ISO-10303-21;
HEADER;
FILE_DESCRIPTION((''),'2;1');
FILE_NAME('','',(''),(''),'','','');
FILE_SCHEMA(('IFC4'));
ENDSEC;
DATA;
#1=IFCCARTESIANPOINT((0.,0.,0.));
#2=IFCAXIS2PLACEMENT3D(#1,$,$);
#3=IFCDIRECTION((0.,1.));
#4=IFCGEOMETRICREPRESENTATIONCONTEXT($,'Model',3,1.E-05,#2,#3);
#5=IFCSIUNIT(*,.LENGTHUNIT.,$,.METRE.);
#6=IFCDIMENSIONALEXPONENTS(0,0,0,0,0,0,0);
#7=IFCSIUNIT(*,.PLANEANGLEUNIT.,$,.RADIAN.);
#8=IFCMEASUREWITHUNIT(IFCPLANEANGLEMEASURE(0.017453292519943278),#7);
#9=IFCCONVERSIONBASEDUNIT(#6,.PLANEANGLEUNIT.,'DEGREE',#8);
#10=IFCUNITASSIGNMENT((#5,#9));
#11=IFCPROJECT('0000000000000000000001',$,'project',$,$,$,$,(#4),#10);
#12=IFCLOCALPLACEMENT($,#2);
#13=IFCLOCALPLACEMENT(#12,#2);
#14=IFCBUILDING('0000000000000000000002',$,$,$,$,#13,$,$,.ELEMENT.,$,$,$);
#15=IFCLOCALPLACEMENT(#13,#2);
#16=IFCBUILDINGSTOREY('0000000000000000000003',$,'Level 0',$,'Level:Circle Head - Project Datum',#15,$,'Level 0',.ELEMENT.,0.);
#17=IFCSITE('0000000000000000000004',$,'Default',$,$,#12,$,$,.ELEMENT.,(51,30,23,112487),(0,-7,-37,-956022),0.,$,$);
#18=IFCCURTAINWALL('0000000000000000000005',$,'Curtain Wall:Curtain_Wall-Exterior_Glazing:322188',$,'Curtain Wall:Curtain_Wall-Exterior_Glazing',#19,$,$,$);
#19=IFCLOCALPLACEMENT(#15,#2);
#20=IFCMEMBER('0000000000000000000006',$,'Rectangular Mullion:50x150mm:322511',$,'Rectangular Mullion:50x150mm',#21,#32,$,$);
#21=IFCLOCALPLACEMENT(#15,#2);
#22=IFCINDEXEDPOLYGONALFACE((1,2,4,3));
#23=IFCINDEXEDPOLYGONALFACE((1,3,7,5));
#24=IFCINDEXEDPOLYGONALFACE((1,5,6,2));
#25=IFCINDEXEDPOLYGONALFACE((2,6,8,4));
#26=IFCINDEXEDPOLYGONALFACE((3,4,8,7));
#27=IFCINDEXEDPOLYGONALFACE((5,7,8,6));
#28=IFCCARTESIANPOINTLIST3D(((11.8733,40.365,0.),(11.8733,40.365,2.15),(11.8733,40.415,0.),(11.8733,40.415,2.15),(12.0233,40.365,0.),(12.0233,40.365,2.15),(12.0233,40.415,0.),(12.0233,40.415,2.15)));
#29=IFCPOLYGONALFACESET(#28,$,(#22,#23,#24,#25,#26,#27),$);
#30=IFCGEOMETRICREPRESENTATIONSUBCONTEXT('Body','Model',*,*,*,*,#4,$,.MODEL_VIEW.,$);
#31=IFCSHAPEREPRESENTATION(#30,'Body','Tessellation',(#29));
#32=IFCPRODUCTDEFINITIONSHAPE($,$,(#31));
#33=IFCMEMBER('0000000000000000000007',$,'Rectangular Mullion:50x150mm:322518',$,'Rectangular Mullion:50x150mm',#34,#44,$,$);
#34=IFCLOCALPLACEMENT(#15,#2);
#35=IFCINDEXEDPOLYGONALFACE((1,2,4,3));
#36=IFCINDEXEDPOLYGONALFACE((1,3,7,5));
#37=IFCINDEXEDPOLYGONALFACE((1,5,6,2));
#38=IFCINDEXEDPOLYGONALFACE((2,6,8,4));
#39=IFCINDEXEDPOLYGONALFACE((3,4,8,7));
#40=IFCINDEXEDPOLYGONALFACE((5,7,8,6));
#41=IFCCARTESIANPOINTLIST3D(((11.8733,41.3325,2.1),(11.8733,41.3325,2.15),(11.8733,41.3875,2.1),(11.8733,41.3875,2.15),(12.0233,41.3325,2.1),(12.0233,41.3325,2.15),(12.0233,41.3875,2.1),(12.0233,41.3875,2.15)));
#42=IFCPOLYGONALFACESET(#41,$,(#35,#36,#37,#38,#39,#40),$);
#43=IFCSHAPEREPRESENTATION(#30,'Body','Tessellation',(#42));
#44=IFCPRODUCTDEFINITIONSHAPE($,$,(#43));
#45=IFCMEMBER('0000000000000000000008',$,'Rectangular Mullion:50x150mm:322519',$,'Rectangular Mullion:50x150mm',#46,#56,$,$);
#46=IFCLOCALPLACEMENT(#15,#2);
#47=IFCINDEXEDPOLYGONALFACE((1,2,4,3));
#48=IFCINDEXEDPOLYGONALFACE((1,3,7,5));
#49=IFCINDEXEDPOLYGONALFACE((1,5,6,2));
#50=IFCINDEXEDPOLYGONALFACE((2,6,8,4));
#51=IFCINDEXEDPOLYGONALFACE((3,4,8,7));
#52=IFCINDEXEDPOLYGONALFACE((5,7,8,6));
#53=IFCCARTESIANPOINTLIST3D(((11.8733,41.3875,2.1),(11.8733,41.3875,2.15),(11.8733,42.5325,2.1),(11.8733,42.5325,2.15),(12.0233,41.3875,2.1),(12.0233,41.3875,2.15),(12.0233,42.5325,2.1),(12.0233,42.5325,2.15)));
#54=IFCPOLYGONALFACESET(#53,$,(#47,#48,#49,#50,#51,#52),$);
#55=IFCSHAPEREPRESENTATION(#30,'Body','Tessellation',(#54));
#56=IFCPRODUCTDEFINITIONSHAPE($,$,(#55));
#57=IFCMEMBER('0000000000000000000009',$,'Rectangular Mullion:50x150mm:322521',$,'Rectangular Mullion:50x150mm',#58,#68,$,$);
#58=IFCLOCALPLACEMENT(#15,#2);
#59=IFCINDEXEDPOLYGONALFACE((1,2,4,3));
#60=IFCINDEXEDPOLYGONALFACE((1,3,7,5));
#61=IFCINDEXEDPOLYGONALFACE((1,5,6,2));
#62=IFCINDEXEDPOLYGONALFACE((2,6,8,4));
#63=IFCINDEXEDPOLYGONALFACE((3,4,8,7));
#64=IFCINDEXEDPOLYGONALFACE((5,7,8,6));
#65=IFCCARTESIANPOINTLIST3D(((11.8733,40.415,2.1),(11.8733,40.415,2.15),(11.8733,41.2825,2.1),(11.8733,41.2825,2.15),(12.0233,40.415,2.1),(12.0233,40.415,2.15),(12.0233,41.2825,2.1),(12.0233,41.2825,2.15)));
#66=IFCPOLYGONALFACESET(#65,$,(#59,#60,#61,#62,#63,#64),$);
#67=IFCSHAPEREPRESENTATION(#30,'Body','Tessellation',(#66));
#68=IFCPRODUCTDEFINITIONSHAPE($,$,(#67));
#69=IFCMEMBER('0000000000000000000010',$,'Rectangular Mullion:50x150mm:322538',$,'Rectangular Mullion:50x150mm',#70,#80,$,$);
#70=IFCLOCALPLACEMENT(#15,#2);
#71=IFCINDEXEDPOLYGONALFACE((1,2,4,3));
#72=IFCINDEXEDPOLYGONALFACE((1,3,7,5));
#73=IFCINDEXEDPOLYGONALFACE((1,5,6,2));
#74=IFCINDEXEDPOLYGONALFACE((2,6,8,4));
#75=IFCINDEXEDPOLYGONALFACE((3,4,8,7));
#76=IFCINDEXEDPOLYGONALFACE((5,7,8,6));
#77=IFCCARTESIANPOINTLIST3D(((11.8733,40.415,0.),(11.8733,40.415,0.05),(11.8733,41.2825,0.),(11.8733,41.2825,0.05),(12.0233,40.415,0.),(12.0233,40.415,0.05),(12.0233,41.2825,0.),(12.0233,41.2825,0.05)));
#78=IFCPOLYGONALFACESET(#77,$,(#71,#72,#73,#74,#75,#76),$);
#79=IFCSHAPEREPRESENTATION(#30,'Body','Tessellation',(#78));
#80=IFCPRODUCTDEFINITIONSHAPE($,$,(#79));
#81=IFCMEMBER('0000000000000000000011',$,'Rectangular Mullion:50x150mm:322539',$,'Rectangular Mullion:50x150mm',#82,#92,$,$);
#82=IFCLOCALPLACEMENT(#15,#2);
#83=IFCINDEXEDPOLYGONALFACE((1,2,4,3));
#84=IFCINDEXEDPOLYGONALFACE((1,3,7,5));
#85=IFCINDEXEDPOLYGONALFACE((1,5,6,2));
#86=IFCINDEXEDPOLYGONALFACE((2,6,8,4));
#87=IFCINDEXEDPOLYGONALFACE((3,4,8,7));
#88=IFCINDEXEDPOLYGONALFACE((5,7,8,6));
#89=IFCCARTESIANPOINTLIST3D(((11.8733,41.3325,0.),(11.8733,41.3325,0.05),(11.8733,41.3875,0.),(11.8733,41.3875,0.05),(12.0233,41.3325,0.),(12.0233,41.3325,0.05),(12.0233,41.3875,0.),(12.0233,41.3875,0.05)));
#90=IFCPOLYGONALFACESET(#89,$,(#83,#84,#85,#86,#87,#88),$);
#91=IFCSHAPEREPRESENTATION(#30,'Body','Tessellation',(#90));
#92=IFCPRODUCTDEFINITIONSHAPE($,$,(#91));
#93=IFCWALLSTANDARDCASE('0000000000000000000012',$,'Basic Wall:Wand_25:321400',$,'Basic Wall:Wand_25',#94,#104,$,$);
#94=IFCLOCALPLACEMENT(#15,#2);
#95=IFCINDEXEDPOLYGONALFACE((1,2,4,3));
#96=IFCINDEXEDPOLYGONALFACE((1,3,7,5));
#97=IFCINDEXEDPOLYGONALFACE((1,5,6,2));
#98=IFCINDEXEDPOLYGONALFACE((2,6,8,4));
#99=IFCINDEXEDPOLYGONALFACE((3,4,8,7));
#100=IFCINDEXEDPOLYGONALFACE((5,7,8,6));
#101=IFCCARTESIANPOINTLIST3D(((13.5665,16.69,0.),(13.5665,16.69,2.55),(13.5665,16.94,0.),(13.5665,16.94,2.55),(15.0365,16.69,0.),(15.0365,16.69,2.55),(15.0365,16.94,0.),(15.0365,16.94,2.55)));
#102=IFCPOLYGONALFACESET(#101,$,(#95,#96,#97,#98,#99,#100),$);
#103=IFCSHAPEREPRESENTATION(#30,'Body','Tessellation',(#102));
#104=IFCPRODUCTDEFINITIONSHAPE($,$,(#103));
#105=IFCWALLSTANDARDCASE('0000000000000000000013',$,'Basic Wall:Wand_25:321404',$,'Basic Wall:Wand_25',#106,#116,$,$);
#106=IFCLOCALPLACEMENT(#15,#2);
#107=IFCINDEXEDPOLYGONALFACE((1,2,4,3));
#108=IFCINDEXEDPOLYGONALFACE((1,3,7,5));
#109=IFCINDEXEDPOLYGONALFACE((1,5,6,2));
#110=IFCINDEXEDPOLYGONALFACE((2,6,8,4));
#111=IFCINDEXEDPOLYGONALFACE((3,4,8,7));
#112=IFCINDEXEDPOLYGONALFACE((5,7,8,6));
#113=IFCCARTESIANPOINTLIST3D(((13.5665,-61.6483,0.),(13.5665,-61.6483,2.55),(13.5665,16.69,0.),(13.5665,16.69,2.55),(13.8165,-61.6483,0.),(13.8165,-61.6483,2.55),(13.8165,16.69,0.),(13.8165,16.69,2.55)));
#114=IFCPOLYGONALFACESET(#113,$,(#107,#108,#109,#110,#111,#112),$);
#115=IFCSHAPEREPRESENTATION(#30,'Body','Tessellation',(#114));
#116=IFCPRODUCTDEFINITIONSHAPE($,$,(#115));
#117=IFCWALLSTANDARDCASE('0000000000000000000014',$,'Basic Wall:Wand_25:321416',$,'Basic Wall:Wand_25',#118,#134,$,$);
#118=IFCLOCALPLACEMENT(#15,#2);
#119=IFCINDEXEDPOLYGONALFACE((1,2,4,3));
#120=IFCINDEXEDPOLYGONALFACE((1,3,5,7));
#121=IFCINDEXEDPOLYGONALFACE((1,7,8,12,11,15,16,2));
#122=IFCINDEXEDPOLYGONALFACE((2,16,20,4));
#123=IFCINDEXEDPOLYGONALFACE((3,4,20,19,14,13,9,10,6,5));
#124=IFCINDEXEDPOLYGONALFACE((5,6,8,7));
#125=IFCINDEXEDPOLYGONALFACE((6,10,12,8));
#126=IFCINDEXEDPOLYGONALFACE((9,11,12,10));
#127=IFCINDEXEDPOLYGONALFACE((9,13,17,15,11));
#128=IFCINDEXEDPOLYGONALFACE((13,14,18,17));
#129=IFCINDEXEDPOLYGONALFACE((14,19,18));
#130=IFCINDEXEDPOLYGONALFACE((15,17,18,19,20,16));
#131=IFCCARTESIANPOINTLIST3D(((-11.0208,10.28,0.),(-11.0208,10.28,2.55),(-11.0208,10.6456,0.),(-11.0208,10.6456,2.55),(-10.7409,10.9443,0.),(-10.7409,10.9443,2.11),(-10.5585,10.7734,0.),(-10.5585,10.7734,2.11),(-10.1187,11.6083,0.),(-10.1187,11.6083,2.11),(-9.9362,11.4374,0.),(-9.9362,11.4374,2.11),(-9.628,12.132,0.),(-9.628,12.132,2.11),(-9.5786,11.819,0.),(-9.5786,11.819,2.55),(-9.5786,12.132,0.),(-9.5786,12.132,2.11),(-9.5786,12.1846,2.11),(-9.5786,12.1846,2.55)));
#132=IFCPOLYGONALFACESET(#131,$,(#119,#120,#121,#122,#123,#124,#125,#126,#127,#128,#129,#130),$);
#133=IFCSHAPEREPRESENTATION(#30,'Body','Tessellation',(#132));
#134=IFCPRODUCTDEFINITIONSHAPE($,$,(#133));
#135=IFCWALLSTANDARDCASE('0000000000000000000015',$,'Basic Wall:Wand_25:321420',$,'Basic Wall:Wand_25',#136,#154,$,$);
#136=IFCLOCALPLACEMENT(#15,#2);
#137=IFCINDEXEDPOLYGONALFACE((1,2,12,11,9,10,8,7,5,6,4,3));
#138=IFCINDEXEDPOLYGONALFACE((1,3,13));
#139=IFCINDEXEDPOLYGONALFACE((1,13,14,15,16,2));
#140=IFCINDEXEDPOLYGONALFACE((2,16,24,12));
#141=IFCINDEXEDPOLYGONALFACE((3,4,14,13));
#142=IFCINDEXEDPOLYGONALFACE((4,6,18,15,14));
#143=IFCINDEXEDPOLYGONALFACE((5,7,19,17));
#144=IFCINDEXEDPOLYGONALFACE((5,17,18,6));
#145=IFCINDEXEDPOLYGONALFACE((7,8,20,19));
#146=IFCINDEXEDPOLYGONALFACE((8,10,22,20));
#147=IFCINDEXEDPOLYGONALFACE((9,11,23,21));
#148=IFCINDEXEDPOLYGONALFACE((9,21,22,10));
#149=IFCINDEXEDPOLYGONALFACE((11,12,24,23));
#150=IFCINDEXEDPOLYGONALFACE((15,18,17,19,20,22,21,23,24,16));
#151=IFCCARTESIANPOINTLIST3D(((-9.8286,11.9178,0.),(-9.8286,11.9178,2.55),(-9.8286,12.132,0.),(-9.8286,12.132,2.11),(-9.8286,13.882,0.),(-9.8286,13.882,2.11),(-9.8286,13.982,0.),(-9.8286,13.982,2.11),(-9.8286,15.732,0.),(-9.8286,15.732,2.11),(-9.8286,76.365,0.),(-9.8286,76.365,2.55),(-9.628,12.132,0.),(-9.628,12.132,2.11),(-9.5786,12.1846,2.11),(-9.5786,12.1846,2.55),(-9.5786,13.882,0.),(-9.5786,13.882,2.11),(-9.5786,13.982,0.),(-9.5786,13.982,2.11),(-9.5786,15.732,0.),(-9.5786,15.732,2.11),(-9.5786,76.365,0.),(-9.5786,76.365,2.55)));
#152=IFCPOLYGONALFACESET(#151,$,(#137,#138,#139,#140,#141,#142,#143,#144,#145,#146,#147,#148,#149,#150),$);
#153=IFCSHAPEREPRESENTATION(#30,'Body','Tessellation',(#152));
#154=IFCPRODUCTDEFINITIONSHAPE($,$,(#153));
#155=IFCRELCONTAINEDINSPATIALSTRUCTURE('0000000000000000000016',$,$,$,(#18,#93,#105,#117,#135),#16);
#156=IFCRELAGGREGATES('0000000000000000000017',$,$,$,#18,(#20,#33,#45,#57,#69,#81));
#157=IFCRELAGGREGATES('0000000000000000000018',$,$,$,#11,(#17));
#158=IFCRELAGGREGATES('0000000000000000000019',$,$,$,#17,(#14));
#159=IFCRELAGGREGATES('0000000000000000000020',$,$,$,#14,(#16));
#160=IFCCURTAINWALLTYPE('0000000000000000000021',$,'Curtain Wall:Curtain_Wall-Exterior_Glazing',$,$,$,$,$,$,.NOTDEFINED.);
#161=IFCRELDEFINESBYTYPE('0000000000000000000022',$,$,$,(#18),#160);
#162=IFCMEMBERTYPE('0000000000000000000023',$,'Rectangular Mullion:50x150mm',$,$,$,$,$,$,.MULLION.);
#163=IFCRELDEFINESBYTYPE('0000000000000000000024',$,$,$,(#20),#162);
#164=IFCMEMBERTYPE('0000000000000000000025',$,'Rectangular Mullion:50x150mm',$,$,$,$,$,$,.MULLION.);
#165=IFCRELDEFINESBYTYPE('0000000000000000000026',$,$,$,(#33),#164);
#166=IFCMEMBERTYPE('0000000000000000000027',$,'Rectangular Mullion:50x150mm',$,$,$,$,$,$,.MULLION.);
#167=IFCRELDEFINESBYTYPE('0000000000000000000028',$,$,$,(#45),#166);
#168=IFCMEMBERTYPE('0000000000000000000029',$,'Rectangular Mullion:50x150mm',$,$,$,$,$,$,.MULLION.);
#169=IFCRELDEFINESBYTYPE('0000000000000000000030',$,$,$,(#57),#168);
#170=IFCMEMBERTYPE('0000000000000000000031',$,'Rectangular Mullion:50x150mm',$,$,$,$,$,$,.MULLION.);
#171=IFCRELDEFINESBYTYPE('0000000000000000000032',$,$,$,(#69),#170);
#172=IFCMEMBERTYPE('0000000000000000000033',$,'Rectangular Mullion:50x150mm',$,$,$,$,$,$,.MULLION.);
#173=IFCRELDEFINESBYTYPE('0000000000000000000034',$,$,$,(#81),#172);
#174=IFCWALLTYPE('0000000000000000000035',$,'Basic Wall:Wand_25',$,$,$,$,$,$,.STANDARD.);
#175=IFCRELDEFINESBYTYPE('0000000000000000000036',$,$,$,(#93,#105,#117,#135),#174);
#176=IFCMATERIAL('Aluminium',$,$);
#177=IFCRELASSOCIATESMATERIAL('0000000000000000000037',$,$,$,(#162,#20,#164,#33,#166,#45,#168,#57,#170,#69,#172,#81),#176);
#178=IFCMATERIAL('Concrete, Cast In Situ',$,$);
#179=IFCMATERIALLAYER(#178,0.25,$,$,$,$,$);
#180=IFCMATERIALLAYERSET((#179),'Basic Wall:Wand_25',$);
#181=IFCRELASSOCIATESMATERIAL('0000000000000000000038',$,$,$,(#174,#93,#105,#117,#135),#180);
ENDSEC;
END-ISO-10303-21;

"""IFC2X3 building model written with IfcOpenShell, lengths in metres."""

from ifc_helpers import new_model, entity, si_unit, converted_unit, direction, frame, frame_2d, origin, origin_2d_with_axis, place, context, subcontext, project, spatial, polyline, rectangle, outline, extrude, source, transform, mapped, material, layer, layer_set, layer_usage, type_object, type_shapes, element, aggregate, save


model = new_model("IFC2X3")

# Units and contexts
model_context = context("Model", 3, precision=1e-05, world=origin(), true_north=direction((0.0, 1.0)))
body_context = subcontext(model_context, "Body", "Model", "MODEL_VIEW")
ifc_project = project(units=[si_unit("LENGTHUNIT", "METRE"), converted_unit("PLANEANGLEUNIT", "DEGREE", entity("IfcPlaneAngleMeasure", 0.017453292519943278), si_unit("PLANEANGLEUNIT", "RADIAN"), dimensions=[0, 0, 0, 0, 0, 0, 0])], contexts=[model_context])

# Site, building, storey
site_placement = place(None, origin())
site = spatial("IfcSite", under=ifc_project, at=site_placement, Name="Default", CompositionType="ELEMENT", RefLatitude=(51, 30, 23, 112487), RefLongitude=(0, -7, -37, -956022), RefElevation=0.0)
building_placement = place(site_placement, origin())
building = spatial("IfcBuilding", under=site, at=building_placement, CompositionType="ELEMENT")
storey_placement = place(building_placement, origin())
storey = spatial("IfcBuildingStorey", under=building, at=storey_placement, Name="Level 0", ObjectType="Level:Circle Head - Project Datum", LongName="Level 0", CompositionType="ELEMENT", Elevation=0.0)

# Curtain wall, members
curtain_wall_type = type_object("IfcCurtainWallType", Name="Curtain Wall:Curtain_Wall-Exterior_Glazing", PredefinedType="NOTDEFINED")
curtain_wall_placement = place(storey_placement, origin())
curtain_wall = element("IfcCurtainWall", 1, at=curtain_wall_placement, inside=storey, type_object=curtain_wall_type, Name="Curtain Wall:Curtain_Wall-Exterior_Glazing:322188", ObjectType="Curtain Wall:Curtain_Wall-Exterior_Glazing")
ifc_material_1 = material(Name="Aluminium")
member_type_1 = type_object("IfcMemberType", Name="Rectangular Mullion:50x150mm", PredefinedType="MULLION", material=ifc_material_1)
shared_shape_1 = source(origin(), body_context, "Body", "SweptSolid", [
    extrude(rectangle(XDim=0.05, YDim=0.15, at=origin_2d_with_axis()), frame((-0.025, 0.0, -2.15), z_axis=(0.0, 0.0, 1.0), x_axis=(-1.0, 0.0, 0.0)), (0.0, 0.0, 1.0), 2.15),
])
type_shapes(member_type_1, [shared_shape_1])
member_1_placement = place(curtain_wall_placement, frame((11.9483, 40.365, 0.0), z_axis=(0.0, 0.0, -1.0), x_axis=(0.0, -1.0, 0.0)))
member_1 = element("IfcMember", 2, at=member_1_placement, type_object=member_type_1, material=ifc_material_1, Name="Rectangular Mullion:50x150mm:322511", ObjectType="Rectangular Mullion:50x150mm", context=body_context, shape_type="MappedRepresentation", body=[
    mapped(shared_shape_1, transform((0.0, 0.0, 0.0), scale=1.0)),
])
member_type_2 = type_object("IfcMemberType", Name="Rectangular Mullion:50x150mm", PredefinedType="MULLION", material=ifc_material_1)
shared_shape_2 = source(origin(), body_context, "Body", "SweptSolid", [
    extrude(rectangle(XDim=0.05, YDim=0.15, at=origin_2d_with_axis()), frame((-0.025, 0.0, -0.055), z_axis=(0.0, 0.0, 1.0), x_axis=(-1.0, 0.0, 0.0)), (0.0, 0.0, 1.0), 0.055),
])
type_shapes(member_type_2, [shared_shape_2])
member_2_placement = place(curtain_wall_placement, frame((11.9483, 41.3325, 2.15), z_axis=(0.0, -1.0, 0.0), x_axis=(0.0, 0.0, 1.0)))
member_2 = element("IfcMember", 3, at=member_2_placement, type_object=member_type_2, material=ifc_material_1, Name="Rectangular Mullion:50x150mm:322518", ObjectType="Rectangular Mullion:50x150mm", context=body_context, shape_type="MappedRepresentation", body=[
    mapped(shared_shape_2, transform((0.0, 0.0, 0.0), scale=1.0)),
])
member_type_3 = type_object("IfcMemberType", Name="Rectangular Mullion:50x150mm", PredefinedType="MULLION", material=ifc_material_1)
shared_shape_3 = source(origin(), body_context, "Body", "SweptSolid", [
    extrude(rectangle(XDim=0.05, YDim=0.15, at=origin_2d_with_axis()), frame((-0.025, 0.0, -1.145), z_axis=(0.0, 0.0, 1.0), x_axis=(-1.0, 0.0, 0.0)), (0.0, 0.0, 1.0), 1.145),
])
type_shapes(member_type_3, [shared_shape_3])
member_3_placement = place(curtain_wall_placement, frame((11.9483, 41.3875, 2.15), z_axis=(0.0, -1.0, 0.0), x_axis=(0.0, 0.0, 1.0)))
member_3 = element("IfcMember", 4, at=member_3_placement, type_object=member_type_3, material=ifc_material_1, Name="Rectangular Mullion:50x150mm:322519", ObjectType="Rectangular Mullion:50x150mm", context=body_context, shape_type="MappedRepresentation", body=[
    mapped(shared_shape_3, transform((0.0, 0.0, 0.0), scale=1.0)),
])
member_type_4 = type_object("IfcMemberType", Name="Rectangular Mullion:50x150mm", PredefinedType="MULLION", material=ifc_material_1)
shared_shape_4 = source(origin(), body_context, "Body", "SweptSolid", [
    extrude(rectangle(XDim=0.05, YDim=0.15, at=origin_2d_with_axis()), frame((-0.025, 0.0, -0.8675), z_axis=(0.0, 0.0, 1.0), x_axis=(-1.0, 0.0, 0.0)), (0.0, 0.0, 1.0), 0.8675),
])
type_shapes(member_type_4, [shared_shape_4])
member_4_placement = place(curtain_wall_placement, frame((11.9483, 40.415, 2.15), z_axis=(0.0, -1.0, 0.0), x_axis=(0.0, 0.0, 1.0)))
member_4 = element("IfcMember", 5, at=member_4_placement, type_object=member_type_4, material=ifc_material_1, Name="Rectangular Mullion:50x150mm:322521", ObjectType="Rectangular Mullion:50x150mm", context=body_context, shape_type="MappedRepresentation", body=[
    mapped(shared_shape_4, transform((0.0, 0.0, 0.0), scale=1.0)),
])
member_type_5 = type_object("IfcMemberType", Name="Rectangular Mullion:50x150mm", PredefinedType="MULLION", material=ifc_material_1)
shared_shape_5 = source(origin(), body_context, "Body", "SweptSolid", [
    extrude(rectangle(XDim=0.05, YDim=0.15, at=origin_2d_with_axis()), frame((-0.025, 0.0, -0.8675), z_axis=(0.0, 0.0, 1.0), x_axis=(-1.0, 0.0, 0.0)), (0.0, 0.0, 1.0), 0.8675),
])
type_shapes(member_type_5, [shared_shape_5])
member_5_placement = place(curtain_wall_placement, frame((11.9483, 41.2825, 0.0), z_axis=(0.0, 1.0, 0.0), x_axis=(0.0, 0.0, -1.0)))
member_5 = element("IfcMember", 6, at=member_5_placement, type_object=member_type_5, material=ifc_material_1, Name="Rectangular Mullion:50x150mm:322538", ObjectType="Rectangular Mullion:50x150mm", context=body_context, shape_type="MappedRepresentation", body=[
    mapped(shared_shape_5, transform((0.0, 0.0, 0.0), scale=1.0)),
])
member_type_6 = type_object("IfcMemberType", Name="Rectangular Mullion:50x150mm", PredefinedType="MULLION", material=ifc_material_1)
shared_shape_6 = source(origin(), body_context, "Body", "SweptSolid", [
    extrude(rectangle(XDim=0.05, YDim=0.15, at=origin_2d_with_axis()), frame((-0.025, 0.0, -0.055), z_axis=(0.0, 0.0, 1.0), x_axis=(-1.0, 0.0, 0.0)), (0.0, 0.0, 1.0), 0.055),
])
type_shapes(member_type_6, [shared_shape_6])
member_6_placement = place(curtain_wall_placement, frame((11.9483, 41.3875, 0.0), z_axis=(0.0, 1.0, 0.0), x_axis=(0.0, 0.0, -1.0)))
member_6 = element("IfcMember", 7, at=member_6_placement, type_object=member_type_6, material=ifc_material_1, Name="Rectangular Mullion:50x150mm:322539", ObjectType="Rectangular Mullion:50x150mm", context=body_context, shape_type="MappedRepresentation", body=[
    mapped(shared_shape_6, transform((0.0, 0.0, 0.0), scale=1.0)),
])
aggregate(curtain_wall, [member_1, member_2, member_3, member_4, member_5, member_6])

# Walls
ifc_material_2 = material(Name="Concrete, Cast In Situ")
ifc_layer_1 = layer(ifc_material_2, 0.25)
ifc_layer_set_1 = layer_set([ifc_layer_1], Name="Basic Wall:Wand_25")
ifc_layer_usage_1 = layer_usage(ifc_layer_set_1, "AXIS2", "NEGATIVE", 0.125)
wall_type_1 = type_object("IfcWallType", Name="Basic Wall:Wand_25", PredefinedType="STANDARD", material=ifc_layer_set_1)
wall_1_placement = place(storey_placement, frame((15.0365, 16.815, 0.0), z_axis=(0.0, 0.0, 1.0), x_axis=(-1.0, 0.0, 0.0)))
element("IfcWallStandardCase", 8, at=wall_1_placement, inside=storey, type_object=wall_type_1, material=ifc_layer_usage_1, Name="Basic Wall:Wand_25:321400", ObjectType="Basic Wall:Wand_25", context=body_context, shape_type="SweptSolid", body=[
    extrude(rectangle(XDim=1.47, YDim=0.25, at=frame_2d((0.735, 0.0), x_axis=(-1.0, 0.0))), origin(), (0.0, 0.0, 1.0), 2.55),
])
wall_2_placement = place(storey_placement, frame((13.6915, 16.69, 0.0), z_axis=(0.0, 0.0, 1.0), x_axis=(0.0, -1.0, 0.0)))
element("IfcWallStandardCase", 9, at=wall_2_placement, inside=storey, type_object=wall_type_1, material=ifc_layer_usage_1, Name="Basic Wall:Wand_25:321404", ObjectType="Basic Wall:Wand_25", context=body_context, shape_type="SweptSolid", body=[
    extrude(rectangle(XDim=78.3384, YDim=0.25, at=frame_2d((39.1692, 0.0), x_axis=(-1.0, 0.0))), origin(), (0.0, 0.0, 1.0), 2.55),
])

# Walls, openings
wall_3_placement = place(storey_placement, frame((-11.1121, 10.3655, 0.0), z_axis=(0.0, 0.0, 1.0), x_axis=(0.683795, 0.729674, 0.0)))
wall_3 = element("IfcWallStandardCase", 10, at=wall_3_placement, inside=storey, type_object=wall_type_1, material=ifc_layer_usage_1, Name="Basic Wall:Wand_25:321416", ObjectType="Basic Wall:Wand_25", context=body_context, shape_type="SweptSolid", body=[
    extrude(outline(polyline([(0.0, -0.125), (2.1092, -0.125), (2.3759, 0.125), (2.0103, 0.125), (0.2668, 0.125), (0.0, -0.125)])), origin(), (0.0, 0.0, 1.0), 2.55),
])
opening_1_placement = place(wall_3_placement, origin())
element("IfcOpeningElement", 11, at=opening_1_placement, cuts=wall_3, ObjectType="Opening", context=body_context, shape_type="SweptSolid", body=[
    extrude(rectangle(XDim=2.11, YDim=1.75, at=frame_2d((0.0, 0.0), x_axis=(0.0, 1.0))), frame((2.976, 0.6873, 1.055), z_axis=(-0.683795, 0.729674, 0.0), x_axis=(0.729674, 0.683795, 0.0)), (0.0, 0.0, 1.0), 0.25),
])
opening_2_placement = place(wall_3_placement, frame((1.5862, 0.125, 0.0)))
element("IfcOpeningElement", 12, at=opening_2_placement, cuts=wall_3, ObjectType="Opening", context=body_context, shape_type="SweptSolid", body=[
    extrude(rectangle(XDim=2.11, YDim=0.91, at=frame_2d((1.055, 0.455), x_axis=(1.0, 0.0))), frame((0.0, 0.0, 0.0), z_axis=(0.0, -1.0, 0.0), x_axis=(0.0, 0.0, 1.0)), (0.0, 0.0, 1.0), 0.25),
])
wall_4_placement = place(storey_placement, frame((-9.7036, 11.9178, 0.0), z_axis=(0.0, 0.0, 1.0), x_axis=(0.0, 1.0, 0.0)))
wall_4 = element("IfcWallStandardCase", 13, at=wall_4_placement, inside=storey, type_object=wall_type_1, material=ifc_layer_usage_1, Name="Basic Wall:Wand_25:321420", ObjectType="Basic Wall:Wand_25", context=body_context, shape_type="SweptSolid", body=[
    extrude(outline(polyline([(0.2668, -0.125), (64.4472, -0.125), (64.4472, 0.125), (0.0, 0.125), (0.2668, -0.125)])), origin(), (0.0, 0.0, 1.0), 2.55),
])
opening_3_placement = place(wall_4_placement, frame((1.9641, 0.125, 0.0)))
element("IfcOpeningElement", 14, at=opening_3_placement, cuts=wall_4, ObjectType="Opening", context=body_context, shape_type="SweptSolid", body=[
    extrude(rectangle(XDim=2.11, YDim=1.75, at=frame_2d((1.055, 0.875), x_axis=(-1.0, 0.0))), frame((0.0, 0.0, 0.0), z_axis=(0.0, -1.0, 0.0), x_axis=(0.0, 0.0, 1.0)), (0.0, 0.0, 1.0), 0.25),
])
opening_4_placement = place(wall_4_placement, frame((3.8141, 0.125, 0.0)))
element("IfcOpeningElement", 15, at=opening_4_placement, cuts=wall_4, ObjectType="Opening", context=body_context, shape_type="SweptSolid", body=[
    extrude(rectangle(XDim=2.11, YDim=1.75, at=frame_2d((1.055, 0.875), x_axis=(-1.0, 0.0))), frame((0.0, 0.0, 0.0), z_axis=(0.0, -1.0, 0.0), x_axis=(0.0, 0.0, 1.0)), (0.0, 0.0, 1.0), 0.25),
])

save(model, "model.ifc")
